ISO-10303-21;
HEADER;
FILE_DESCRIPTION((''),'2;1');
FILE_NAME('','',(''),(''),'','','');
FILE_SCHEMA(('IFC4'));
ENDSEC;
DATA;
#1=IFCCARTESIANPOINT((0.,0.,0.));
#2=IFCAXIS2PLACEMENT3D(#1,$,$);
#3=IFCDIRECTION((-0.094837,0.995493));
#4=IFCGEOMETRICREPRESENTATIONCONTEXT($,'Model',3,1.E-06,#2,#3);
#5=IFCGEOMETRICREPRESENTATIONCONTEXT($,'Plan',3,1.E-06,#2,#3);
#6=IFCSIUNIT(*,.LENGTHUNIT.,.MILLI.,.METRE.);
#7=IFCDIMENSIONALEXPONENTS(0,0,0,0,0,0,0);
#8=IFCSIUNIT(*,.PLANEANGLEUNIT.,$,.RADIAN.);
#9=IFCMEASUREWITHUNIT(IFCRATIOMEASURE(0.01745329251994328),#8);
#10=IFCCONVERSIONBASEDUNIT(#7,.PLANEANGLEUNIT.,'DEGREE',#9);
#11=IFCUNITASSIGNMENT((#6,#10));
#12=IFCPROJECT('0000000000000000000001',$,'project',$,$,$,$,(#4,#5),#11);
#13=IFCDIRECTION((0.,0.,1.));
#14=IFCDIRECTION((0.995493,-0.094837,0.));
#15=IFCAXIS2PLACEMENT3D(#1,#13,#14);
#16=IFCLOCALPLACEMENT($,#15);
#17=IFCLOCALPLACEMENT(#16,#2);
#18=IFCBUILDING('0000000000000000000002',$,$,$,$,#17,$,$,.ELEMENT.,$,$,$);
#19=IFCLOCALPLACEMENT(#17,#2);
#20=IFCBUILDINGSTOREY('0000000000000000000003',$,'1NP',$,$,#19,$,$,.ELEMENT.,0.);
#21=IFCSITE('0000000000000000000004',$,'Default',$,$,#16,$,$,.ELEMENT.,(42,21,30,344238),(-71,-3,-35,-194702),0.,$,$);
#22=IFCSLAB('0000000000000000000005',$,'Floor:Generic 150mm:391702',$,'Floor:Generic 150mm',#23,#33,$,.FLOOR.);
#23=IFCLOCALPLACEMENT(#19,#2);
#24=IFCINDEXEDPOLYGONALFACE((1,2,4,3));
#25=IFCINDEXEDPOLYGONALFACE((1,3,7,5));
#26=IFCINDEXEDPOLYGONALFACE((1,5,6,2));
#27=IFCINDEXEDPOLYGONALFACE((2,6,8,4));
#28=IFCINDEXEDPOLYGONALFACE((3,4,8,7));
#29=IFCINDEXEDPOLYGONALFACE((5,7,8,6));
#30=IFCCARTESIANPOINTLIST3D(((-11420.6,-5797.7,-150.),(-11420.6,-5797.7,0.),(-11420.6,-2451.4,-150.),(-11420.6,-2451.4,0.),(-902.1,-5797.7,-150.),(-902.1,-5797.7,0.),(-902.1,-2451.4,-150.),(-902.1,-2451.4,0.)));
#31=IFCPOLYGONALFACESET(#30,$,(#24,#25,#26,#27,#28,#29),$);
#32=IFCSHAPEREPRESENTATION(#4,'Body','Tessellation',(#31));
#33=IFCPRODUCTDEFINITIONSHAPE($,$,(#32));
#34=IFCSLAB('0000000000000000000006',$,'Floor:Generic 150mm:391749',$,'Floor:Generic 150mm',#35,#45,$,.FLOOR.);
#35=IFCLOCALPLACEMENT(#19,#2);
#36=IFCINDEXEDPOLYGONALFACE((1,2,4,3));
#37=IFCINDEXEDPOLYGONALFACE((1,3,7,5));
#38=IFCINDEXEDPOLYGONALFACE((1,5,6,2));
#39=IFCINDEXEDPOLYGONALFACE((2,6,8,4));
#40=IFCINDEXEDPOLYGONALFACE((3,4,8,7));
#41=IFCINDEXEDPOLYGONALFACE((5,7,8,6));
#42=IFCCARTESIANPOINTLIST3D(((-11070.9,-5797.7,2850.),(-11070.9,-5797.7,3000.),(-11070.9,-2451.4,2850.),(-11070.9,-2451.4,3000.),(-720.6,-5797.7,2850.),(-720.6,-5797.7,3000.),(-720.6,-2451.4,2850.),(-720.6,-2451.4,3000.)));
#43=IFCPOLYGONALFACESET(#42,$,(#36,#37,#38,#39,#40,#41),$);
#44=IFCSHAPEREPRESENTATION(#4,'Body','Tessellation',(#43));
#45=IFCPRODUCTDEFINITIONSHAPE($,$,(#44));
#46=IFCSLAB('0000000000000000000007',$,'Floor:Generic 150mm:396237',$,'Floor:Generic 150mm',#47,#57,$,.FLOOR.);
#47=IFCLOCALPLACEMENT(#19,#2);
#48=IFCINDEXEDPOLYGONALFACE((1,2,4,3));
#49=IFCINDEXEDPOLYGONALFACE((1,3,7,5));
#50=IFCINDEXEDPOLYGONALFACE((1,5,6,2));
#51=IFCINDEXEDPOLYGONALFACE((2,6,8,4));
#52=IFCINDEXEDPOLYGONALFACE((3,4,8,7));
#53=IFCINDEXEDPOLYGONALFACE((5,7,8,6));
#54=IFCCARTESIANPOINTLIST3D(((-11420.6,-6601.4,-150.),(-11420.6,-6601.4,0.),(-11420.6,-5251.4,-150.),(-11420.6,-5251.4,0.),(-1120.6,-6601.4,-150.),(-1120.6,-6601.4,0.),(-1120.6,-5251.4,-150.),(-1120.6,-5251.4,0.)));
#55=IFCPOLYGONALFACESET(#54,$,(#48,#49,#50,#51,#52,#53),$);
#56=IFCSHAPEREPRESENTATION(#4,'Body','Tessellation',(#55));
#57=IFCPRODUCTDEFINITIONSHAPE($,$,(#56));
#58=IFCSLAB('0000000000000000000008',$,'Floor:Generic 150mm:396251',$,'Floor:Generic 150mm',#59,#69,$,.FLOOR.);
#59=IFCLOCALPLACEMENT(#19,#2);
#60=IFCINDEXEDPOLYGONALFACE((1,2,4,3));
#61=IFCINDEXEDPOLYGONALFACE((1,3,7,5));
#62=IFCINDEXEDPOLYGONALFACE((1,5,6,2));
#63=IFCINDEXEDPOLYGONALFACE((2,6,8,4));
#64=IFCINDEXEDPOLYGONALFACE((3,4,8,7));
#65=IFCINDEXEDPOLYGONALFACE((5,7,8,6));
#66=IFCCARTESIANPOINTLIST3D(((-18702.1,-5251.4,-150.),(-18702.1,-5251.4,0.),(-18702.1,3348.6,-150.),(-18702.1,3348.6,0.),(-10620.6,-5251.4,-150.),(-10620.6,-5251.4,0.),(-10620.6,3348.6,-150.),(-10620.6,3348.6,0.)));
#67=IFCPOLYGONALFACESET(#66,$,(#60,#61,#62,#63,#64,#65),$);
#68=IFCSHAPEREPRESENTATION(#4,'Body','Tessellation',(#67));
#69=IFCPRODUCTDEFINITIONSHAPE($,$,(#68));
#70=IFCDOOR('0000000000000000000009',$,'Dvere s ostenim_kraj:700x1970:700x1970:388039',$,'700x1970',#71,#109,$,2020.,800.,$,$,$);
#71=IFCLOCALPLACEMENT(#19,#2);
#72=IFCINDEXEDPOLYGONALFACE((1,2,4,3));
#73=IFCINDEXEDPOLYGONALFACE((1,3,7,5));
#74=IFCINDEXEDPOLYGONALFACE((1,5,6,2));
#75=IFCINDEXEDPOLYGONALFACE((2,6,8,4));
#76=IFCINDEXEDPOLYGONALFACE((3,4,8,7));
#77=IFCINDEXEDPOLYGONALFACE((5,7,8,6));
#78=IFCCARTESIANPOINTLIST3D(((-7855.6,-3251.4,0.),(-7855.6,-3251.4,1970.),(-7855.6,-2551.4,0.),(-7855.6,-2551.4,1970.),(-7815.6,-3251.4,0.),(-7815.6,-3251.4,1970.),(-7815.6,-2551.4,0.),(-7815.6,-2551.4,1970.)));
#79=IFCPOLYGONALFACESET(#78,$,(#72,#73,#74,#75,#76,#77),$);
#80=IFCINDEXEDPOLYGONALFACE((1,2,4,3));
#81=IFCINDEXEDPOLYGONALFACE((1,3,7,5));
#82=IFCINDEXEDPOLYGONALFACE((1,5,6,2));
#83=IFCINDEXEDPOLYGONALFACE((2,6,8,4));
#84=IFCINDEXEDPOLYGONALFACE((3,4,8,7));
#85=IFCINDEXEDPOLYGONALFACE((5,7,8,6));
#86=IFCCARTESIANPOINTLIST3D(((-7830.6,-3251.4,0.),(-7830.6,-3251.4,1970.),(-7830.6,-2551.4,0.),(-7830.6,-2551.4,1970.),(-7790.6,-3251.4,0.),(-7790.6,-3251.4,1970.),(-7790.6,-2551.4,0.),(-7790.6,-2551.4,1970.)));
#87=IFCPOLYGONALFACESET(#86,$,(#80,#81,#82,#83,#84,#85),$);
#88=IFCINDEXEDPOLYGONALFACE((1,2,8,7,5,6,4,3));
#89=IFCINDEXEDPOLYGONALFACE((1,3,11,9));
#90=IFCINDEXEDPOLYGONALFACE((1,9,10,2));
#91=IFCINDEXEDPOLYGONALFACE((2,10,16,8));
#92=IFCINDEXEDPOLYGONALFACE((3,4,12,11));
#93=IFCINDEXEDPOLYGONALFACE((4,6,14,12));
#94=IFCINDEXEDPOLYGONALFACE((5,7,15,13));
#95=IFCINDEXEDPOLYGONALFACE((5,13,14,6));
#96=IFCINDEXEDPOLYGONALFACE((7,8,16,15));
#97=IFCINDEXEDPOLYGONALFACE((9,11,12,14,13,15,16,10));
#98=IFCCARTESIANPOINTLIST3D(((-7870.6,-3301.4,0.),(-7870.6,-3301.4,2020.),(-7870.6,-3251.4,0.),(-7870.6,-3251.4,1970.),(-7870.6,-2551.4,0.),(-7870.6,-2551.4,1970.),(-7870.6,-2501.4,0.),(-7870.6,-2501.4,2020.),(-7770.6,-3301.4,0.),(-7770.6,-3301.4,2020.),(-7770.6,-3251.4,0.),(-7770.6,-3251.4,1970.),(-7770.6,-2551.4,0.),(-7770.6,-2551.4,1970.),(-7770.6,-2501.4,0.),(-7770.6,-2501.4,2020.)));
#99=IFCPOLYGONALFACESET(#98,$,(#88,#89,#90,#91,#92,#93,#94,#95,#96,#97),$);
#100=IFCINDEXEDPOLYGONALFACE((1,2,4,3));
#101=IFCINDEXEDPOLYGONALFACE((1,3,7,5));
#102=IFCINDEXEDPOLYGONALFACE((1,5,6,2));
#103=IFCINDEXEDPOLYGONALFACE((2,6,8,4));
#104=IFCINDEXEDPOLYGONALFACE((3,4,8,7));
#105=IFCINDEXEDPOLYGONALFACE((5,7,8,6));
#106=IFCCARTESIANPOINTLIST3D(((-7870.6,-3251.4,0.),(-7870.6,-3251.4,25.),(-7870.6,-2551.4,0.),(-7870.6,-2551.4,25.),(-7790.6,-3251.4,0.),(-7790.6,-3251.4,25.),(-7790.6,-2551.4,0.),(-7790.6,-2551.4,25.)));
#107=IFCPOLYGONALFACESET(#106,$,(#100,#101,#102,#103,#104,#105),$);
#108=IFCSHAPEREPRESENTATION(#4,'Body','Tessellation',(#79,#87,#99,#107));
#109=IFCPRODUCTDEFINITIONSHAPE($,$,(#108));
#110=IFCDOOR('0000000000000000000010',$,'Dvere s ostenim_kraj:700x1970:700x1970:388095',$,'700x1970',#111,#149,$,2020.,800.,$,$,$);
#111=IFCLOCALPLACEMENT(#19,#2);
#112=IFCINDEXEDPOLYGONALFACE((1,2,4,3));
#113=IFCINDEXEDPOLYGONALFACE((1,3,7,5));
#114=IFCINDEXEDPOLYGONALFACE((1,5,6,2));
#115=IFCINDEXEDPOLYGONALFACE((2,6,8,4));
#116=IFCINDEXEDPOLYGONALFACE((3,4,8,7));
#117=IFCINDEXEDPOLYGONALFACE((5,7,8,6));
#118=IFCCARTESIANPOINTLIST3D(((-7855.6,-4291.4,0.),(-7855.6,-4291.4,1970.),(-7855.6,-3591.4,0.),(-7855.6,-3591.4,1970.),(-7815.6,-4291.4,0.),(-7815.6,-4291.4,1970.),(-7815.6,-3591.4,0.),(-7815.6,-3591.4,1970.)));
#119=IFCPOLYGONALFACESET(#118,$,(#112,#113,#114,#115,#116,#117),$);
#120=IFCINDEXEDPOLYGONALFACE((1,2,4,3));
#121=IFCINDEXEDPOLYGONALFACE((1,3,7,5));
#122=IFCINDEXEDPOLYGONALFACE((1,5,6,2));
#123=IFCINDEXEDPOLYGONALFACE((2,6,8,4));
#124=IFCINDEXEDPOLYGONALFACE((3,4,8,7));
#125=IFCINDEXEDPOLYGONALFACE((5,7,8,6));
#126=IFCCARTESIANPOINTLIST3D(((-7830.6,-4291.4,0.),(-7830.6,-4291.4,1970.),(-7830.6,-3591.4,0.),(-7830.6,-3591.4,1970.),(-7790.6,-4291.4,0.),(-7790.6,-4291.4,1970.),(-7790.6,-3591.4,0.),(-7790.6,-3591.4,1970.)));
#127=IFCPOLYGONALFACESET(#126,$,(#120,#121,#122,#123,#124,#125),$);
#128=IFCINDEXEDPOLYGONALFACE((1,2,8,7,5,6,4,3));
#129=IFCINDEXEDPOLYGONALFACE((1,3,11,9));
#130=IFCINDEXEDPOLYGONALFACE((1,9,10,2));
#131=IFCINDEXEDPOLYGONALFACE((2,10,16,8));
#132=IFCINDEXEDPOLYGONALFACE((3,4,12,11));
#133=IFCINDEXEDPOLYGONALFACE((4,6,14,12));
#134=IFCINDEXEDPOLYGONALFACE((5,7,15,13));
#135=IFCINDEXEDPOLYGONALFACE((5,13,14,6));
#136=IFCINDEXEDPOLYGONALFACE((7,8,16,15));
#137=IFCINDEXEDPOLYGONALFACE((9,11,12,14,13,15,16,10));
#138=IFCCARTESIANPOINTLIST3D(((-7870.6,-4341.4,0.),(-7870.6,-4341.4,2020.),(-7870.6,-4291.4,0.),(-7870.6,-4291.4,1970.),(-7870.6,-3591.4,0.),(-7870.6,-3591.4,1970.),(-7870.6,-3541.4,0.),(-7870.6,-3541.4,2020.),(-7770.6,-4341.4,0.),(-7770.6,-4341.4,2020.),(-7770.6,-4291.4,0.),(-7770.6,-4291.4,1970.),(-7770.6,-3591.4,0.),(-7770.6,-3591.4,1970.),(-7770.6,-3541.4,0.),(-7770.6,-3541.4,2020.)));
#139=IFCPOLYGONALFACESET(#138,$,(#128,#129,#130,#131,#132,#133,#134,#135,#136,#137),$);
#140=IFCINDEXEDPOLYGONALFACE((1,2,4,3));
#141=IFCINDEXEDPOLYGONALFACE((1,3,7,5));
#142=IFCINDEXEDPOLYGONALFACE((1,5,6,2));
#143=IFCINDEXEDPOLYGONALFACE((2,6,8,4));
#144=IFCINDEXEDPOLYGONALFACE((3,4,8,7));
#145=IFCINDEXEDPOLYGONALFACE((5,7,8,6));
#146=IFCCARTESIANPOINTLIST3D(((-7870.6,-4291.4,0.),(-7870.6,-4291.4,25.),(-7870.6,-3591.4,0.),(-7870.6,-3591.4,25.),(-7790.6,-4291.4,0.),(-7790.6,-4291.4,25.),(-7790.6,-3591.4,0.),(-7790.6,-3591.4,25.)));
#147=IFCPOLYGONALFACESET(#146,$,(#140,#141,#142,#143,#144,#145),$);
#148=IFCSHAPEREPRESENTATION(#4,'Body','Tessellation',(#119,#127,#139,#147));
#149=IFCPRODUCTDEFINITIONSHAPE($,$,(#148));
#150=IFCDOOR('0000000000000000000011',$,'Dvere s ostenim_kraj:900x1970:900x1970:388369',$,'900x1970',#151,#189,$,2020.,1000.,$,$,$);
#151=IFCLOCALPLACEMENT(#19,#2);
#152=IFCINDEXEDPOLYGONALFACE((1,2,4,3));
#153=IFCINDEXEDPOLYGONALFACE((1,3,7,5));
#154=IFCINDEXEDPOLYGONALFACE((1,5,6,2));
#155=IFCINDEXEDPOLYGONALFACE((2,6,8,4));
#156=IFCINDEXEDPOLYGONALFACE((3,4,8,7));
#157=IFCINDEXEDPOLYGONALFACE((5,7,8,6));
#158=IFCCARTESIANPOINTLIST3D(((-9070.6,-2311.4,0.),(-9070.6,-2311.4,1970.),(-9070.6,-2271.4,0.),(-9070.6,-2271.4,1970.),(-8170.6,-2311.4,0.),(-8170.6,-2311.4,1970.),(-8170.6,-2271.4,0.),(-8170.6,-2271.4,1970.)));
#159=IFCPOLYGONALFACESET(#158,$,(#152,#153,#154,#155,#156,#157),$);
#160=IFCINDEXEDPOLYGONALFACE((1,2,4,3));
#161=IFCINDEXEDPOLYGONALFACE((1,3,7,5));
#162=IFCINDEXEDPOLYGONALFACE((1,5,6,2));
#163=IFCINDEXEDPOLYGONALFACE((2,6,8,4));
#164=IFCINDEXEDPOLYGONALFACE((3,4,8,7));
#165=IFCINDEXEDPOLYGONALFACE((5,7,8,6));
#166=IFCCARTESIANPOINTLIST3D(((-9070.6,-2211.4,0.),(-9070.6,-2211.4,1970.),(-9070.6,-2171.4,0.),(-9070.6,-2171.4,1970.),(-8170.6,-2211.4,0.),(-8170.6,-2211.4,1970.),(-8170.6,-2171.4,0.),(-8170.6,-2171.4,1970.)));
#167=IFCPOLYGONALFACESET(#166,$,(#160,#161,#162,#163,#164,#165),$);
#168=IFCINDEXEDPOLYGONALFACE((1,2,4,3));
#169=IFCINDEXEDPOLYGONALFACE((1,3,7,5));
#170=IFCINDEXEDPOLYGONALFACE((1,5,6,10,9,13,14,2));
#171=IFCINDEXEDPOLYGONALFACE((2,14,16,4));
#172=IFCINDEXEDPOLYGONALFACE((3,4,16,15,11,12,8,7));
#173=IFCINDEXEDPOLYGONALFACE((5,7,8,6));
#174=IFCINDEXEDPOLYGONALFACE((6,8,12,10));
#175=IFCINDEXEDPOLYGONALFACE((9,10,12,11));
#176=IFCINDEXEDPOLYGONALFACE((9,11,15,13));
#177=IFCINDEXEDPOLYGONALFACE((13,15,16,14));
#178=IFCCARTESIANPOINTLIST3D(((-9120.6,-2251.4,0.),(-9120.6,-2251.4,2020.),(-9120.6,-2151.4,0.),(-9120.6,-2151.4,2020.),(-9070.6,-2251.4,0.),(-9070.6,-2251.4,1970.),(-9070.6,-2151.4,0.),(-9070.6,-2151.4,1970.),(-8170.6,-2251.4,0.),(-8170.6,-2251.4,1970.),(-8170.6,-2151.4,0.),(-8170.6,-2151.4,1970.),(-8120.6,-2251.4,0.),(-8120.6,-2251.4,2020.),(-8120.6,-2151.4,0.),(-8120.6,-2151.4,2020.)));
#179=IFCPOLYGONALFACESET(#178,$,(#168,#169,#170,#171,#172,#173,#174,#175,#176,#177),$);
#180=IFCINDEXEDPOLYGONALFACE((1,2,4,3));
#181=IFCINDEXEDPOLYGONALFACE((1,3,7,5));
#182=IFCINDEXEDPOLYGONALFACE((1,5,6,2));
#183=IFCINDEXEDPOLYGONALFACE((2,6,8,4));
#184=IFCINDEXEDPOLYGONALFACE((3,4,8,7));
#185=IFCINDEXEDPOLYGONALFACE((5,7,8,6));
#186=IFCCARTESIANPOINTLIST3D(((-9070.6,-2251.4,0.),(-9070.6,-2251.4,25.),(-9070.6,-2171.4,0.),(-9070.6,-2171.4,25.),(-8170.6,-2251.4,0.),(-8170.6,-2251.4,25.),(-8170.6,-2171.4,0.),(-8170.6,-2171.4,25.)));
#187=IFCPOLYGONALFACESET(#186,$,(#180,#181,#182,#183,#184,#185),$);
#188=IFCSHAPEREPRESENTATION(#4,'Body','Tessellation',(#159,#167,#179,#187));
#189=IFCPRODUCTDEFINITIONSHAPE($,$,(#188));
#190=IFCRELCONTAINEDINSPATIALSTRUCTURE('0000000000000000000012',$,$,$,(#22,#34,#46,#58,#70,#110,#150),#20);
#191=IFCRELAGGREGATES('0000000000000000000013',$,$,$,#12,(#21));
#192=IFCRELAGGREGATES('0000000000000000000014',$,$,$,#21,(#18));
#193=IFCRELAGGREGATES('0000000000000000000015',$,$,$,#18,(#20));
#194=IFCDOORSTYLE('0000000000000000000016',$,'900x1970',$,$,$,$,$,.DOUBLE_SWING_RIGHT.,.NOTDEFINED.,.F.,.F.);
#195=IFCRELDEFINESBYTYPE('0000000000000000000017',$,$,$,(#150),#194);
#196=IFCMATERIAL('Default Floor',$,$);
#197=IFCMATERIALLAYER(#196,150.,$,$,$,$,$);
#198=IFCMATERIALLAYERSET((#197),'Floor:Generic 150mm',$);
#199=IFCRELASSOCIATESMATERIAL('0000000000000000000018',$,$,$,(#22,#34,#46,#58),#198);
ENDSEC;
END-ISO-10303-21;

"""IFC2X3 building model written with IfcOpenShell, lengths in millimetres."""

from ifc_helpers import new_model, entity, si_unit, converted_unit, direction, frame, frame_2d, origin, origin_2d_with_axis, place, context, project, spatial, polyline, rectangle, outline, extrude, source, transform, mapped, material, layer, layer_set, layer_usage, type_object, type_shapes, element, save


model = new_model("IFC2X3")

# Units and contexts
model_context = context("Model", 3, precision=1e-06, world=origin(), true_north=direction((-0.094837, 0.995493)))
plan_context = context("Plan", 3, precision=1e-06, world=origin(), true_north=direction((-0.094837, 0.995493)))
ifc_project = project(units=[si_unit("LENGTHUNIT", "METRE", prefix="MILLI"), converted_unit("PLANEANGLEUNIT", "DEGREE", entity("IfcRatioMeasure", 0.01745329251994328), si_unit("PLANEANGLEUNIT", "RADIAN"), dimensions=[0, 0, 0, 0, 0, 0, 0])], contexts=[model_context, plan_context])

# Site, building, storey
site_placement = place(None, frame((0.0, 0.0, 0.0), z_axis=(0.0, 0.0, 1.0), x_axis=(0.995493, -0.094837, 0.0)))
site = spatial("IfcSite", under=ifc_project, at=site_placement, Name="Default", CompositionType="ELEMENT", RefLatitude=(42, 21, 30, 344238), RefLongitude=(-71, -3, -35, -194702), RefElevation=0.0)
building_placement = place(site_placement, origin())
building = spatial("IfcBuilding", under=site, at=building_placement, CompositionType="ELEMENT")
storey_placement = place(building_placement, origin())
storey = spatial("IfcBuildingStorey", under=building, at=storey_placement, Name="1NP", CompositionType="ELEMENT", Elevation=0.0)

# Slabs
ifc_material_1 = material(Name="Default Floor")
ifc_layer_1 = layer(ifc_material_1, 150.0)
ifc_layer_set_1 = layer_set([ifc_layer_1], Name="Floor:Generic 150mm")
ifc_layer_usage_1 = layer_usage(ifc_layer_set_1, "AXIS3", "POSITIVE", 0.0)
slab_1_placement = place(storey_placement, frame((-11420.6, -5797.7, -150.0)))
element("IfcSlab", 1, at=slab_1_placement, inside=storey, material=ifc_layer_usage_1, Name="Floor:Generic 150mm:391702", ObjectType="Floor:Generic 150mm", PredefinedType="FLOOR", context=model_context, shape_type="SweptSolid", body=[
    extrude(rectangle(XDim=3346.3, YDim=10518.5, at=frame_2d((0.0, 0.0), x_axis=(0.0, -1.0))), frame((5259.3, 1673.1, 150.0), z_axis=(0.0, 0.0, -1.0), x_axis=(-1.0, 0.0, 0.0)), (0.0, 0.0, 1.0), 150.0),
])
ifc_layer_usage_2 = layer_usage(ifc_layer_set_1, "AXIS3", "POSITIVE", 0.0)
slab_2_placement = place(storey_placement, frame((-11070.9, -5797.7, 2850.0)))
element("IfcSlab", 2, at=slab_2_placement, inside=storey, material=ifc_layer_usage_2, Name="Floor:Generic 150mm:391749", ObjectType="Floor:Generic 150mm", PredefinedType="FLOOR", context=model_context, shape_type="SweptSolid", body=[
    extrude(rectangle(XDim=3346.3, YDim=10350.2, at=frame_2d((-5175.1, 1673.1), x_axis=(0.0, -1.0))), frame((10350.2, 0.0, 150.0)), (0.0, 0.0, -1.0), 150.0),
])
ifc_layer_usage_3 = layer_usage(ifc_layer_set_1, "AXIS3", "POSITIVE", 0.0)
slab_3_placement = place(storey_placement, frame((-11420.6, -6601.4, -150.0)))
element("IfcSlab", 3, at=slab_3_placement, inside=storey, material=ifc_layer_usage_3, Name="Floor:Generic 150mm:396237", ObjectType="Floor:Generic 150mm", PredefinedType="FLOOR", context=model_context, shape_type="SweptSolid", body=[
    extrude(rectangle(XDim=1350.0, YDim=10300.0, at=frame_2d((0.0, 0.0), x_axis=(0.0, -1.0))), frame((5150.0, 675.0, 150.0), z_axis=(0.0, 0.0, -1.0), x_axis=(-1.0, 0.0, 0.0)), (0.0, 0.0, 1.0), 150.0),
])
ifc_layer_usage_4 = layer_usage(ifc_layer_set_1, "AXIS3", "POSITIVE", 0.0)
slab_4_placement = place(storey_placement, frame((-18702.1, -5251.4, -150.0)))
element("IfcSlab", 4, at=slab_4_placement, inside=storey, material=ifc_layer_usage_4, Name="Floor:Generic 150mm:396251", ObjectType="Floor:Generic 150mm", PredefinedType="FLOOR", context=model_context, shape_type="SweptSolid", body=[
    extrude(rectangle(XDim=8081.5, YDim=8600.0, at=frame_2d((0.0, 0.0), x_axis=(-1.0, 0.0))), frame((4040.7, 4300.0, 150.0), z_axis=(0.0, 0.0, -1.0), x_axis=(-1.0, 0.0, 0.0)), (0.0, 0.0, 1.0), 150.0),
])

# Doors
shared_shape_1 = source(origin(), model_context, "Body", "SweptSolid", [
    extrude(rectangle(XDim=700.0, YDim=40.0, at=origin_2d_with_axis()), frame((400.0, 85.0, 0.0), z_axis=(0.0, 0.0, 1.0), x_axis=(-1.0, 0.0, 0.0)), (0.0, 0.0, 1.0), 1970.0),
    extrude(rectangle(XDim=700.0, YDim=40.0, at=origin_2d_with_axis()), frame((400.0, 110.0, 0.0), z_axis=(0.0, 0.0, 1.0), x_axis=(-1.0, 0.0, 0.0)), (0.0, 0.0, 1.0), 1970.0),
    extrude(outline(polyline([(-997.5, -350.0), (-997.5, -400.0), (1022.5, -400.0), (1022.5, 400.0), (-997.5, 400.0), (-997.5, 350.0), (972.5, 350.0), (972.5, -350.0), (-997.5, -350.0)])), frame((400.0, 50.0, 997.5), z_axis=(0.0, -1.0, 0.0), x_axis=(0.0, 0.0, 1.0)), (0.0, 0.0, -1.0), 100.0),
    extrude(rectangle(XDim=700.0, YDim=80.0, at=origin_2d_with_axis()), frame((400.0, 90.0, 0.0), z_axis=(0.0, 0.0, 1.0), x_axis=(-1.0, 0.0, 0.0)), (0.0, 0.0, 1.0), 25.0),
])
wall_1_placement = place(storey_placement, frame((-7845.6, -2451.4, 0.0), z_axis=(0.0, 0.0, 1.0), x_axis=(0.0, -1.0, 0.0)))
opening_1_placement = place(wall_1_placement, frame((50.0, -75.0, 0.0)))
door_1_placement = place(opening_1_placement, origin())
element("IfcDoor", 5, at=door_1_placement, inside=storey, Name="Dvere s ostenim_kraj:700x1970:700x1970:388039", ObjectType="700x1970", OverallHeight=2020.0, OverallWidth=800.0, context=model_context, shape_type="MappedRepresentation", body=[
    mapped(shared_shape_1, transform((0.0, 0.0, 0.0), scale=1.0)),
])
opening_2_placement = place(wall_1_placement, frame((1090.0, -75.0, 0.0)))
door_2_placement = place(opening_2_placement, origin())
element("IfcDoor", 6, at=door_2_placement, inside=storey, Name="Dvere s ostenim_kraj:700x1970:700x1970:388095", ObjectType="700x1970", OverallHeight=2020.0, OverallWidth=800.0, context=model_context, shape_type="MappedRepresentation", body=[
    mapped(shared_shape_1, transform((0.0, 0.0, 0.0), scale=1.0)),
])
door_style = type_object("IfcDoorStyle", Name="900x1970", ConstructionType="NOTDEFINED", OperationType="DOUBLE_SWING_RIGHT", ParameterTakesPrecedence=False, Sizeable=False)
shared_shape_2 = source(origin(), model_context, "Body", "SweptSolid", [
    extrude(rectangle(XDim=40.0, YDim=900.0, at=origin_2d_with_axis()), frame((600.0, 160.0, 0.0), z_axis=(0.0, 0.0, 1.0), x_axis=(0.0, -1.0, 0.0)), (0.0, 0.0, 1.0), 1970.0),
    extrude(rectangle(XDim=40.0, YDim=900.0, at=origin_2d_with_axis()), frame((600.0, 260.0, 0.0), z_axis=(0.0, 0.0, 1.0), x_axis=(0.0, -1.0, 0.0)), (0.0, 0.0, 1.0), 1970.0),
    extrude(outline(polyline([(-500.0, -997.5), (-450.0, -997.5), (-450.0, 972.5), (450.0, 972.5), (450.0, -997.5), (500.0, -997.5), (500.0, 1022.5), (-500.0, 1022.5), (-500.0, -997.5)])), frame((600.0, 300.0, 997.5), z_axis=(0.0, -1.0, 0.0), x_axis=(1.0, 0.0, 0.0)), (0.0, 0.0, 1.0), 100.0),
    extrude(rectangle(XDim=80.0, YDim=900.0, at=origin_2d_with_axis()), frame((600.0, 240.0, 0.0), z_axis=(0.0, 0.0, 1.0), x_axis=(0.0, -1.0, 0.0)), (0.0, 0.0, 1.0), 25.0),
])
type_shapes(door_style, [shared_shape_2])
wall_2_placement = place(storey_placement, frame((-10320.6, -2301.4, 0.0)))
opening_3_placement = place(wall_2_placement, frame((1200.0, -150.0, 0.0)))
door_3_placement = place(opening_3_placement, frame((-100.0, 0.0, 0.0)))
element("IfcDoor", 7, at=door_3_placement, inside=storey, type_object=door_style, Name="Dvere s ostenim_kraj:900x1970:900x1970:388369", ObjectType="900x1970", OverallHeight=2020.0, OverallWidth=1000.0, context=model_context, shape_type="MappedRepresentation", body=[
    mapped(shared_shape_2, transform((0.0, 0.0, 0.0), scale=1.0)),
])

save(model, "model.ifc")
